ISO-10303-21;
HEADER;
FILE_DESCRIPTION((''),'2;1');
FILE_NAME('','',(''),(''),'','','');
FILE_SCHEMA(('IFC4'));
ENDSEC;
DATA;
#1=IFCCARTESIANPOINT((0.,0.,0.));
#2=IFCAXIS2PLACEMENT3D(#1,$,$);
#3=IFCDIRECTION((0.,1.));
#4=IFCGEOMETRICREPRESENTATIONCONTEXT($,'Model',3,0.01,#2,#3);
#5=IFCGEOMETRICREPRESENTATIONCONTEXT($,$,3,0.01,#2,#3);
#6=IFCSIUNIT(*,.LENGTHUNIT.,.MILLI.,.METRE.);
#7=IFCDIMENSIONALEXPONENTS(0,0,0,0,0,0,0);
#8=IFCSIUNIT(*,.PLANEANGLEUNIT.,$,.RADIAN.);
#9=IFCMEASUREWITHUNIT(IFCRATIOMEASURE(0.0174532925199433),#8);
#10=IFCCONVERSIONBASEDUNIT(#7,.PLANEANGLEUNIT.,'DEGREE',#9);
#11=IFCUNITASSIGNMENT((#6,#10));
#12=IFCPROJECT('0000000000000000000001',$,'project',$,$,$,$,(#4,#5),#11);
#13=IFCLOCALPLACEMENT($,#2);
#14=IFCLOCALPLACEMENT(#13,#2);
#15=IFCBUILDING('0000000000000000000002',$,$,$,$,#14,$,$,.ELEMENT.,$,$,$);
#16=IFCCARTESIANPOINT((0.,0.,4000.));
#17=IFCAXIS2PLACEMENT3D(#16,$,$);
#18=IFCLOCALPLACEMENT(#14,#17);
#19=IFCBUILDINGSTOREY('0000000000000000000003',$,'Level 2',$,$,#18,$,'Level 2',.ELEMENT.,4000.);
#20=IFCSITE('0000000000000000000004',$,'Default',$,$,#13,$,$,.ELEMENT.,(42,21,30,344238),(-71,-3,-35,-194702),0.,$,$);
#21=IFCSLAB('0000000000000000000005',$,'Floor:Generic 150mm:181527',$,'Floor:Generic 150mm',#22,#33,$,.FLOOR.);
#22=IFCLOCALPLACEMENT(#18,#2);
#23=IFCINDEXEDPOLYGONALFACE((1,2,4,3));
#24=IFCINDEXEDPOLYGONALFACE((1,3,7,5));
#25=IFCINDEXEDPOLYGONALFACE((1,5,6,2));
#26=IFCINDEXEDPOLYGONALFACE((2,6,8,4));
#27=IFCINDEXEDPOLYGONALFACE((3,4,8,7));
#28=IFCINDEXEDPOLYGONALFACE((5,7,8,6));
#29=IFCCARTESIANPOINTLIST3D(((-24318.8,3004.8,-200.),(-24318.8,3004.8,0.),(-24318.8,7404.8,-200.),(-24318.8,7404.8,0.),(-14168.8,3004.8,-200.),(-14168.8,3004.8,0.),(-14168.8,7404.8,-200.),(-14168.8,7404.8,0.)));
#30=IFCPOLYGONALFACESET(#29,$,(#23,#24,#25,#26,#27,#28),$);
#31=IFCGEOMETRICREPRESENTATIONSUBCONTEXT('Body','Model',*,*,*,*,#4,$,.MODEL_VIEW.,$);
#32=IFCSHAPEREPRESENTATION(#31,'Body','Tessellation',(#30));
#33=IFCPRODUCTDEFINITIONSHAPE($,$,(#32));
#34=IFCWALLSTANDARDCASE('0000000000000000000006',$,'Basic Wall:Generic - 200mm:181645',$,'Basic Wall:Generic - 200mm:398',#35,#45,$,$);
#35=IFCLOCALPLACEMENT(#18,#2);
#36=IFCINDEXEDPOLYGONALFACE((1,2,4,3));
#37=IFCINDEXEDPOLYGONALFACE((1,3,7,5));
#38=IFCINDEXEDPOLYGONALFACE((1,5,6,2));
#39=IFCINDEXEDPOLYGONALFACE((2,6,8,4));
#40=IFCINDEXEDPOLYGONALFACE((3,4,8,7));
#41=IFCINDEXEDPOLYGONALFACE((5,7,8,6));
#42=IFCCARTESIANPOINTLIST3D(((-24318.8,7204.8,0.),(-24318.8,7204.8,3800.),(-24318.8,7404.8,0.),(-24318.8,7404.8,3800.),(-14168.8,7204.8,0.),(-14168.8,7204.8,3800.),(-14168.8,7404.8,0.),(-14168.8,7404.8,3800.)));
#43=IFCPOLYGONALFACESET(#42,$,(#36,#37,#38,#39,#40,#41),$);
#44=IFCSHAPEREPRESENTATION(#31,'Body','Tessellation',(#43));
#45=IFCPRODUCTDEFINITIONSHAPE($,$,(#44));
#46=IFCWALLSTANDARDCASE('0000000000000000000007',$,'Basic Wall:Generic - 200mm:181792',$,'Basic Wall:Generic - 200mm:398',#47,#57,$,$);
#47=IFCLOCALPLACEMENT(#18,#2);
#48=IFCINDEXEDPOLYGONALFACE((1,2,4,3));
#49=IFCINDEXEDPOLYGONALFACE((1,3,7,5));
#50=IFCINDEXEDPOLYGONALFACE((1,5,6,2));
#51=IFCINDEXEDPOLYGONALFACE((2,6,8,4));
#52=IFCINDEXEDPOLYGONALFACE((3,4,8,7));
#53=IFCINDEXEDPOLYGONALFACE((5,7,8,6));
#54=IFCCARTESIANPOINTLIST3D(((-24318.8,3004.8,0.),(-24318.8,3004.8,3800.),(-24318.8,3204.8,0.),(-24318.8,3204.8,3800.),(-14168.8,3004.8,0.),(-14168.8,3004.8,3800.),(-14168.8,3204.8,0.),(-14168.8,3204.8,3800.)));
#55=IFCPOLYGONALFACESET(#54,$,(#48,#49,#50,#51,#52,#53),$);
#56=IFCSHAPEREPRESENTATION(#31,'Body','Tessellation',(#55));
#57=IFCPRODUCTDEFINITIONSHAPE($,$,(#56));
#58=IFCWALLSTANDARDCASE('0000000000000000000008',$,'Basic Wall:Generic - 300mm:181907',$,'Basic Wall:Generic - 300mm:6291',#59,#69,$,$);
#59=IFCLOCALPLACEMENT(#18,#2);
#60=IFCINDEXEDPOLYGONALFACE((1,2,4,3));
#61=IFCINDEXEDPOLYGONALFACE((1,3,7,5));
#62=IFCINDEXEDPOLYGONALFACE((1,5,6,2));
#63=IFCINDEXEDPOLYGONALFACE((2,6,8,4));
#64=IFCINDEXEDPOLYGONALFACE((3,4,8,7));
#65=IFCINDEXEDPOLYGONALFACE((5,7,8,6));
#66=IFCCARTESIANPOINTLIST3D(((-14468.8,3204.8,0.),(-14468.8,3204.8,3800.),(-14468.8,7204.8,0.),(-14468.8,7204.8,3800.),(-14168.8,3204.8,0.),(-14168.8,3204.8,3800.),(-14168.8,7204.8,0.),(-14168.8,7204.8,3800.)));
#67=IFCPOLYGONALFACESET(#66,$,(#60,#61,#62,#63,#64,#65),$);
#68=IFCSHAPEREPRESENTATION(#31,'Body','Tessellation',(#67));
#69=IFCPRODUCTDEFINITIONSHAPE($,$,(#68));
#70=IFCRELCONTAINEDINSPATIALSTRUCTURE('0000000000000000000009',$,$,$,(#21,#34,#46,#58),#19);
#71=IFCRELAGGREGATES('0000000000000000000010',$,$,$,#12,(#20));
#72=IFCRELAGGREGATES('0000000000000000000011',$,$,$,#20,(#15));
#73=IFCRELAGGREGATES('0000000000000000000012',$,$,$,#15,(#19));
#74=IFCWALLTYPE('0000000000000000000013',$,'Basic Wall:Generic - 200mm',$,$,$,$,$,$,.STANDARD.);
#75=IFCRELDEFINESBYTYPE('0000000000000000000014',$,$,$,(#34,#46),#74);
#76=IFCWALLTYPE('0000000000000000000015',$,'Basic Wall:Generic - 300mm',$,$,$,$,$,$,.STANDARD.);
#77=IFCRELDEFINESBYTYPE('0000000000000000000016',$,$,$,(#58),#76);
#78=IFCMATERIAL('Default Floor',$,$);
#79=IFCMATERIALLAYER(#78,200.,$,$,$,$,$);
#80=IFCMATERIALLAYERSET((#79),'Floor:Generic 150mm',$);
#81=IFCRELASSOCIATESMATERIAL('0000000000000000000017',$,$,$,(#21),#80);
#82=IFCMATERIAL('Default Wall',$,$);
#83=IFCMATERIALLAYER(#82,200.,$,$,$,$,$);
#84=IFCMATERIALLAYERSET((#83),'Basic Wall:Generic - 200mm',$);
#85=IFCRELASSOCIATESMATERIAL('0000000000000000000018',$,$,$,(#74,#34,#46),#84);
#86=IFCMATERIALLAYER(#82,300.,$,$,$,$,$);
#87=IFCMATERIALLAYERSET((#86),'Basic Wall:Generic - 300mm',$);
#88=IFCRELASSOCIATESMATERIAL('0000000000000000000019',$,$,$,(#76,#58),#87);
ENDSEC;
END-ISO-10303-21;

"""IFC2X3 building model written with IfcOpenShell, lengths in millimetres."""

from ifc_helpers import new_model, entity, si_unit, converted_unit, direction, frame, frame_2d, origin, place, context, subcontext, project, spatial, rectangle, extrude, material, layer, layer_set, layer_usage, type_object, element, save


model = new_model("IFC2X3")

# Units and contexts
model_context = context("Model", 3, precision=0.01, world=origin(), true_north=direction((0.0, 1.0)))
context_of_model = context(None, 3, precision=0.01, world=origin(), true_north=direction((0.0, 1.0)))
body_context = subcontext(model_context, "Body", "Model", "MODEL_VIEW")
ifc_project = project(units=[si_unit("LENGTHUNIT", "METRE", prefix="MILLI"), converted_unit("PLANEANGLEUNIT", "DEGREE", entity("IfcRatioMeasure", 0.0174532925199433), si_unit("PLANEANGLEUNIT", "RADIAN"), dimensions=[0, 0, 0, 0, 0, 0, 0])], contexts=[model_context, context_of_model])

# Site, building, storey
site_placement = place(None, origin())
site = spatial("IfcSite", under=ifc_project, at=site_placement, Name="Default", CompositionType="ELEMENT", RefLatitude=(42, 21, 30, 344238), RefLongitude=(-71, -3, -35, -194702), RefElevation=0.0)
building_placement = place(site_placement, origin())
building = spatial("IfcBuilding", under=site, at=building_placement, CompositionType="ELEMENT")
storey_placement = place(building_placement, frame((0.0, 0.0, 4000.0)))
storey = spatial("IfcBuildingStorey", under=building, at=storey_placement, Name="Level 2", LongName="Level 2", CompositionType="ELEMENT", Elevation=4000.0)

# Slab
ifc_material_1 = material(Name="Default Floor")
ifc_layer_1 = layer(ifc_material_1, 200.0)
ifc_layer_set_1 = layer_set([ifc_layer_1], Name="Floor:Generic 150mm")
ifc_layer_usage_1 = layer_usage(ifc_layer_set_1, "AXIS3", "POSITIVE", 0.0)
slab_placement = place(storey_placement, origin())
element("IfcSlab", 1, at=slab_placement, inside=storey, material=ifc_layer_usage_1, Name="Floor:Generic 150mm:181527", ObjectType="Floor:Generic 150mm", PredefinedType="FLOOR", context=body_context, shape_type="SweptSolid", body=[
    extrude(rectangle(XDim=4400.0, YDim=10150.0, at=frame_2d((0.0, 0.0), x_axis=(1.0, 0.0))), frame((-19243.8, 5204.8, 0.0), z_axis=(0.0, 0.0, -1.0), x_axis=(0.0, 1.0, 0.0)), (0.0, 0.0, 1.0), 200.0),
])

# Walls
ifc_material_2 = material(Name="Default Wall")
ifc_layer_2 = layer(ifc_material_2, 200.0)
ifc_layer_set_2 = layer_set([ifc_layer_2], Name="Basic Wall:Generic - 200mm")
ifc_layer_usage_2 = layer_usage(ifc_layer_set_2, "AXIS2", "NEGATIVE", 100.0)
wall_type_1 = type_object("IfcWallType", Name="Basic Wall:Generic - 200mm", PredefinedType="STANDARD", material=ifc_layer_set_2)
wall_1_placement = place(storey_placement, frame((-24318.8, 7304.8, 0.0)))
element("IfcWallStandardCase", 2, at=wall_1_placement, inside=storey, type_object=wall_type_1, material=ifc_layer_usage_2, Name="Basic Wall:Generic - 200mm:181645", ObjectType="Basic Wall:Generic - 200mm:398", context=body_context, shape_type="SweptSolid", body=[
    extrude(rectangle(XDim=10150.0, YDim=200.0, at=frame_2d((5075.0, 0.0), x_axis=(-1.0, 0.0))), origin(), (0.0, 0.0, 1.0), 3800.0),
])
ifc_layer_usage_3 = layer_usage(ifc_layer_set_2, "AXIS2", "NEGATIVE", 100.0)
wall_2_placement = place(storey_placement, frame((-14168.8, 3104.8, 0.0), z_axis=(0.0, 0.0, 1.0), x_axis=(-1.0, 0.0, 0.0)))
element("IfcWallStandardCase", 3, at=wall_2_placement, inside=storey, type_object=wall_type_1, material=ifc_layer_usage_3, Name="Basic Wall:Generic - 200mm:181792", ObjectType="Basic Wall:Generic - 200mm:398", context=body_context, shape_type="SweptSolid", body=[
    extrude(rectangle(XDim=10150.0, YDim=200.0, at=frame_2d((5075.0, 0.0), x_axis=(-1.0, 0.0))), origin(), (0.0, 0.0, 1.0), 3800.0),
])
ifc_layer_3 = layer(ifc_material_2, 300.0)
ifc_layer_set_3 = layer_set([ifc_layer_3], Name="Basic Wall:Generic - 300mm")
ifc_layer_usage_4 = layer_usage(ifc_layer_set_3, "AXIS2", "NEGATIVE", 150.0)
wall_type_2 = type_object("IfcWallType", Name="Basic Wall:Generic - 300mm", PredefinedType="STANDARD", material=ifc_layer_set_3)
wall_3_placement = place(storey_placement, frame((-14318.8, 7204.8, 0.0), z_axis=(0.0, 0.0, 1.0), x_axis=(0.0, -1.0, 0.0)))
element("IfcWallStandardCase", 4, at=wall_3_placement, inside=storey, type_object=wall_type_2, material=ifc_layer_usage_4, Name="Basic Wall:Generic - 300mm:181907", ObjectType="Basic Wall:Generic - 300mm:6291", context=body_context, shape_type="SweptSolid", body=[
    extrude(rectangle(XDim=4000.0, YDim=300.0, at=frame_2d((2000.0, 0.0), x_axis=(-1.0, 0.0))), origin(), (0.0, 0.0, 1.0), 3800.0),
])

save(model, "model.ifc")
